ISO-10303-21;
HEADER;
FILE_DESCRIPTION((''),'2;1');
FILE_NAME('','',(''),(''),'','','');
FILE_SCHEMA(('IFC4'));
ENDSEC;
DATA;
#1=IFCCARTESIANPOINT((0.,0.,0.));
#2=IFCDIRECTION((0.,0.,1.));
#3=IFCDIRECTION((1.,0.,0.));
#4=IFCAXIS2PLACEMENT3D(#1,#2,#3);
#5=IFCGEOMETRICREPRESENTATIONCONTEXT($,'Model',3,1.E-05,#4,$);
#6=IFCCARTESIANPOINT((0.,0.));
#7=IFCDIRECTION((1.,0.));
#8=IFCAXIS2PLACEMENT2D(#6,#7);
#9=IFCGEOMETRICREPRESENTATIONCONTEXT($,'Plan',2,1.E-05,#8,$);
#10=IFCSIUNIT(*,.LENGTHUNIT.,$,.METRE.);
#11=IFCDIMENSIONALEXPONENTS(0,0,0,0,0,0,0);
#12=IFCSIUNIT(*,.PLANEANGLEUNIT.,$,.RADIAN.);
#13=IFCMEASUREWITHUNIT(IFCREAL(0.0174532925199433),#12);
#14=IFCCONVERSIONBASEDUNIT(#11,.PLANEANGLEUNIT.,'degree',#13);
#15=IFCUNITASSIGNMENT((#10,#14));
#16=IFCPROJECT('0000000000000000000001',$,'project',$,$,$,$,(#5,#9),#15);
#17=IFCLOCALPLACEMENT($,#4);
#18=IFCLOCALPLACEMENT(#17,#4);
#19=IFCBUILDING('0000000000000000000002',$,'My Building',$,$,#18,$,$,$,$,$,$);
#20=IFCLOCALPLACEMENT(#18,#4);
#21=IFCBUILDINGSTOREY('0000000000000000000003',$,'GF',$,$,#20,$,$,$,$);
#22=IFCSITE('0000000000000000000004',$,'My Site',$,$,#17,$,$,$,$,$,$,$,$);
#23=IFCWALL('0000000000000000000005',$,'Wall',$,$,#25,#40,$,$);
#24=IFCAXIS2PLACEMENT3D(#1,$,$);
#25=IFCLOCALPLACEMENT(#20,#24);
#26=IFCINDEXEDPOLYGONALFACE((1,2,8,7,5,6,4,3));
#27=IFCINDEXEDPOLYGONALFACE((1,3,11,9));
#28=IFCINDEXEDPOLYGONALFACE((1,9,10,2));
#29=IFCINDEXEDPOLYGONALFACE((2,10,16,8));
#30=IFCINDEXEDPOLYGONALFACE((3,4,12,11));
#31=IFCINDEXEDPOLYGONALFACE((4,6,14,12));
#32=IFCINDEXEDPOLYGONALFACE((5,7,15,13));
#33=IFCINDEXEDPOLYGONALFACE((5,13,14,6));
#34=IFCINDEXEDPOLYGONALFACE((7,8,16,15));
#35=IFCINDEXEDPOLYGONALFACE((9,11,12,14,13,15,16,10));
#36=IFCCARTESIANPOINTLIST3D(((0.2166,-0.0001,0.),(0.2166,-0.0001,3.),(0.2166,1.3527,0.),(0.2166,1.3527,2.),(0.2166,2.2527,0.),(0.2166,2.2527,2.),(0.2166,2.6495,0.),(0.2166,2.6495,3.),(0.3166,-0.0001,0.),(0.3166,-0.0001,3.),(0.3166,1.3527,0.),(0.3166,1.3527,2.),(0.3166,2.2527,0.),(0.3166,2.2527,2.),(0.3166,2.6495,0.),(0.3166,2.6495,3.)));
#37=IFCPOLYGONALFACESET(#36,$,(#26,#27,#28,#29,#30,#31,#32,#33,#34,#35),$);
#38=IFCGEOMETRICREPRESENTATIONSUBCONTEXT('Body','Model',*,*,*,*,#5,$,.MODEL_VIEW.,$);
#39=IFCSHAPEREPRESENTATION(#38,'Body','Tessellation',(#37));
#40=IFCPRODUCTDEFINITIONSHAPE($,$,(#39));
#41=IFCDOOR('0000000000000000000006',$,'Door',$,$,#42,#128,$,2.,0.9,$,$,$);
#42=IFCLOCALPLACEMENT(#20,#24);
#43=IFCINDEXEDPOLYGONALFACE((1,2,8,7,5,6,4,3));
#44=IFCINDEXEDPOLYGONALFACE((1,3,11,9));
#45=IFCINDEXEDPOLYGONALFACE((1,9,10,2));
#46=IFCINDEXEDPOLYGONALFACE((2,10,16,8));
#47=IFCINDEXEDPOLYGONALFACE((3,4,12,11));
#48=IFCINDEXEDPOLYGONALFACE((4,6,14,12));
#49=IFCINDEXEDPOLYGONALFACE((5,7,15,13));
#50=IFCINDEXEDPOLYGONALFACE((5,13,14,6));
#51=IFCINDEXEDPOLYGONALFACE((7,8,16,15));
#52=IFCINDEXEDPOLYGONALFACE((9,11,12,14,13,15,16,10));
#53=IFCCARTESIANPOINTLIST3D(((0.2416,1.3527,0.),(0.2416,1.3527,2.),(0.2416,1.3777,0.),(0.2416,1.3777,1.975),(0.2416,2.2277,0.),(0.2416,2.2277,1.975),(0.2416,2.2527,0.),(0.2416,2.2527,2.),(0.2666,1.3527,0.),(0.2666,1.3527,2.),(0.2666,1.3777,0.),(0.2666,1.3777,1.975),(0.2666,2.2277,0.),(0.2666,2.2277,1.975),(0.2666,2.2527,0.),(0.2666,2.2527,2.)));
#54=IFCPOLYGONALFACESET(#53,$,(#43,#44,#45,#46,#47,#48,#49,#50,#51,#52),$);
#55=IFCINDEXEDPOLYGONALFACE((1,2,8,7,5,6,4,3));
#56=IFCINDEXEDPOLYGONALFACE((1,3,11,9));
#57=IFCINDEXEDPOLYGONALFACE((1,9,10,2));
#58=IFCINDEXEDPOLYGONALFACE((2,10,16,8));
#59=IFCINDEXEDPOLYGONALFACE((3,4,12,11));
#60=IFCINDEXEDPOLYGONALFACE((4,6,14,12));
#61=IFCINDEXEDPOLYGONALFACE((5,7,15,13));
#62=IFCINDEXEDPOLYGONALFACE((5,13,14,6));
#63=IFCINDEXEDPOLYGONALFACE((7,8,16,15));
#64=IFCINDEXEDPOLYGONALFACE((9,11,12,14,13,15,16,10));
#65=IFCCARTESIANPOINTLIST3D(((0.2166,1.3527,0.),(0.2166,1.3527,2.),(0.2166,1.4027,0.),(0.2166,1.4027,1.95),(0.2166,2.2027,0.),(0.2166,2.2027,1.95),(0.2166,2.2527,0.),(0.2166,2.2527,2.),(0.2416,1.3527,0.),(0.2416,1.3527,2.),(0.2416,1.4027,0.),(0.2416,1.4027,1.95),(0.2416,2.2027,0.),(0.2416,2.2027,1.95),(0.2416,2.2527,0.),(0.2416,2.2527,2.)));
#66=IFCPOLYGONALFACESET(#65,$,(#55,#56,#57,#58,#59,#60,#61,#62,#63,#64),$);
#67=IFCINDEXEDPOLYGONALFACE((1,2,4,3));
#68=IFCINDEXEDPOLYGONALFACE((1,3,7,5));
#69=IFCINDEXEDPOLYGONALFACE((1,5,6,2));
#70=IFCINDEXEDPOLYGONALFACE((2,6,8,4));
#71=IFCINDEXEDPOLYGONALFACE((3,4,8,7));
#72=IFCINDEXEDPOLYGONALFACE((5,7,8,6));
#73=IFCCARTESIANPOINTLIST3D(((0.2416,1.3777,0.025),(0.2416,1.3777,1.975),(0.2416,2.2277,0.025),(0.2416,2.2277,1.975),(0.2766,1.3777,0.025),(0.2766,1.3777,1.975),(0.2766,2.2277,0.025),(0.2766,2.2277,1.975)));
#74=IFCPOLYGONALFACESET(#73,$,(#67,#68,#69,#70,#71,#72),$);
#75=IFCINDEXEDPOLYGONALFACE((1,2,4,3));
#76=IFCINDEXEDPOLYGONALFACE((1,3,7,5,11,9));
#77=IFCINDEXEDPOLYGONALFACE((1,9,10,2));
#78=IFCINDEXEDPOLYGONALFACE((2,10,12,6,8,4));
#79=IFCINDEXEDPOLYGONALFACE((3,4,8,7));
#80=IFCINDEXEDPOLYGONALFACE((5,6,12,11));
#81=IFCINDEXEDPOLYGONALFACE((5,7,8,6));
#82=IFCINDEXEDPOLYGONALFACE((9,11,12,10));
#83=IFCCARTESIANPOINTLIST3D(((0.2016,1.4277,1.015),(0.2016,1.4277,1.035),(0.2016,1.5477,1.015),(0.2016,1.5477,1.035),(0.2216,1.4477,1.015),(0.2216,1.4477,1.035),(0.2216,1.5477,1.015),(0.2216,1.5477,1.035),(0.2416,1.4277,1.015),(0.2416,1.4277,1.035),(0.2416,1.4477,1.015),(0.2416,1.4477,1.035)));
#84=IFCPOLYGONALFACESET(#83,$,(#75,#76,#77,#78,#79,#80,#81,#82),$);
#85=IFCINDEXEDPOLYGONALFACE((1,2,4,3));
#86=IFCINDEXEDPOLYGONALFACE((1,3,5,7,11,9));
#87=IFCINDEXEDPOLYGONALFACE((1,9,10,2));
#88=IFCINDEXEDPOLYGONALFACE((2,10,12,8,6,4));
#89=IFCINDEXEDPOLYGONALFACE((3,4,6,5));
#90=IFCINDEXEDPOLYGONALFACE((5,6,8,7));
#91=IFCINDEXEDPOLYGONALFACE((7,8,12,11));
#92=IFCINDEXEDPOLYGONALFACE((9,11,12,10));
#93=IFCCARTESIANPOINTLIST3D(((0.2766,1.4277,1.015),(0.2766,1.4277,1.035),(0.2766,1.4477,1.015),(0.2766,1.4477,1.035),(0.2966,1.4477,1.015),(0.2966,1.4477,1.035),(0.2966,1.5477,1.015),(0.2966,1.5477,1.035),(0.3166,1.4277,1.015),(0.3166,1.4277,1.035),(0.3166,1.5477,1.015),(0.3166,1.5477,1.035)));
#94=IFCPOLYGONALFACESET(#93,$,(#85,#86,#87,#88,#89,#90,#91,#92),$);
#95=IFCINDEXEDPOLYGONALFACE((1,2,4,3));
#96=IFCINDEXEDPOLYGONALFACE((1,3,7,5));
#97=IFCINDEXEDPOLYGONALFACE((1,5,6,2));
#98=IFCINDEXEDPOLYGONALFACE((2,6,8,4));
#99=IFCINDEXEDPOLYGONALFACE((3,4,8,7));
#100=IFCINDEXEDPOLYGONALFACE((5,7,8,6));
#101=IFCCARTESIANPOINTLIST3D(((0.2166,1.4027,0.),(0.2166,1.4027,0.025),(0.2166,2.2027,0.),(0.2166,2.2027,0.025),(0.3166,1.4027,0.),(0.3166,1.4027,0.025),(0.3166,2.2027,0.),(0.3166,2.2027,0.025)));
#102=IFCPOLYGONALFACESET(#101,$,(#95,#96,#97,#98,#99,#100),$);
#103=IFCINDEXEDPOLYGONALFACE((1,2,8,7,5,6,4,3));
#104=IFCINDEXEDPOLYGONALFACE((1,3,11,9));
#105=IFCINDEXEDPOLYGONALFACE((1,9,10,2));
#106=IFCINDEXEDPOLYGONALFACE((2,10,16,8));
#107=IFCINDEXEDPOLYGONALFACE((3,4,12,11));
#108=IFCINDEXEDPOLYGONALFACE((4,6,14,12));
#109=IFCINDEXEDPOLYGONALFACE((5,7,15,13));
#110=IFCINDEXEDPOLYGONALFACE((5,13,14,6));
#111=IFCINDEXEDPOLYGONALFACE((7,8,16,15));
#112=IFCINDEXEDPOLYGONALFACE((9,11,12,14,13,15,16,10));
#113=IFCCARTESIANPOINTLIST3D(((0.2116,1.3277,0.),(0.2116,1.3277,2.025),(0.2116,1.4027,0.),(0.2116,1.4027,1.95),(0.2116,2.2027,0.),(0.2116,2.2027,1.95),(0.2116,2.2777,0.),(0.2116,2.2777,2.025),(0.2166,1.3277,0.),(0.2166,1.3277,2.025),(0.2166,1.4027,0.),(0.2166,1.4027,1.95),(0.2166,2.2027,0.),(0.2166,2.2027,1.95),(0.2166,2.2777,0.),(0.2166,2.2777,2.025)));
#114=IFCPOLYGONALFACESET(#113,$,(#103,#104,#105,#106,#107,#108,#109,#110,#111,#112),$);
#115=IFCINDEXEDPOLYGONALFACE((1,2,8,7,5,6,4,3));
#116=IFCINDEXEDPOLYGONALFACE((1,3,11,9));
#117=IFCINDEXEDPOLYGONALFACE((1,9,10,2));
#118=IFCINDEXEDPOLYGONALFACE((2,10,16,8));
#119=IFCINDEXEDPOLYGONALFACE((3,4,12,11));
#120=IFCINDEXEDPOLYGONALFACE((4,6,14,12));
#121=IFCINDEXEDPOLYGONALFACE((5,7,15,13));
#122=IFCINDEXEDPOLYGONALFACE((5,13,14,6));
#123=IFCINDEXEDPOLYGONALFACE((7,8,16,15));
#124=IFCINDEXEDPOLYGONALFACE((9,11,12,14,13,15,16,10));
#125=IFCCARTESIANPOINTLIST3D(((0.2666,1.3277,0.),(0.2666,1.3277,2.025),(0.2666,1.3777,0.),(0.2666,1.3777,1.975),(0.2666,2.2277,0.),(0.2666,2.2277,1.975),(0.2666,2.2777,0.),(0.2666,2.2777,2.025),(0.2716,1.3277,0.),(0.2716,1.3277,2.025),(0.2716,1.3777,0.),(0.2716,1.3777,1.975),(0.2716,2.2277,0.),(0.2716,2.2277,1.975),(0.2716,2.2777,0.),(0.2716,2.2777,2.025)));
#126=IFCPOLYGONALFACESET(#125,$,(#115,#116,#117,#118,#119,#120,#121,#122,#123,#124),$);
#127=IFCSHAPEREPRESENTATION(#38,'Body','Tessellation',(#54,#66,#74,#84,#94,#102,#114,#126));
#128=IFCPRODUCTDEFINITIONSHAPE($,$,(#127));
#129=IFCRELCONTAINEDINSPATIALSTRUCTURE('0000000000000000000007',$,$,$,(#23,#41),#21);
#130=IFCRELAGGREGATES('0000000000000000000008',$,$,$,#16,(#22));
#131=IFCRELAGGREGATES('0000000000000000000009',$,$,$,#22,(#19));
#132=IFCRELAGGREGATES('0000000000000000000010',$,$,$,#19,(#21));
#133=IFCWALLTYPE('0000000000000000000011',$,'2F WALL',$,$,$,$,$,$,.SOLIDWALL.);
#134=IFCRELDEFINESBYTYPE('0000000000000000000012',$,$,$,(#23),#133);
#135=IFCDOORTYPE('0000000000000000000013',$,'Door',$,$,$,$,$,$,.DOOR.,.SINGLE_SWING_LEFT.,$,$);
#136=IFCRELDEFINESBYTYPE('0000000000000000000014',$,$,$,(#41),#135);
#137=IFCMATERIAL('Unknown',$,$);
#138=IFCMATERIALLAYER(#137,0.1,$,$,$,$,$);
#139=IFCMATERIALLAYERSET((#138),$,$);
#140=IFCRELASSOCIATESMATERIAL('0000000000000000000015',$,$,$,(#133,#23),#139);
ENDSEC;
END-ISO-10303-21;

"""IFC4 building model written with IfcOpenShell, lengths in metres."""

from ifc_helpers import new_model, entity, si_unit, converted_unit, frame, origin_with_axes, origin_2d_with_axis, place, context, subcontext, project, spatial, line, indexed_curve, outline, extrude, shape, source, transform, mapped, material, layer, layer_set, layer_usage, type_object, type_shapes, element, fill, save


model = new_model("IFC4")

# Units and contexts
model_context = context("Model", 3, precision=1e-05, world=origin_with_axes())
plan_context = context("Plan", 2, precision=1e-05, world=origin_2d_with_axis())
body_context_1 = subcontext(model_context, "Body", "Model", "MODEL_VIEW")
body_context_2 = subcontext(plan_context, "Body", "Plan", "PLAN_VIEW")
ifc_project = project(units=[si_unit("LENGTHUNIT", "METRE"), converted_unit("PLANEANGLEUNIT", "degree", entity("IfcReal", 0.0174532925199433), si_unit("PLANEANGLEUNIT", "RADIAN"), dimensions=[0, 0, 0, 0, 0, 0, 0])], contexts=[model_context, plan_context])

# Site, building, storey
site_placement = place(None, origin_with_axes())
site = spatial("IfcSite", under=ifc_project, at=site_placement, Name="My Site")
building_placement = place(site_placement, origin_with_axes())
building = spatial("IfcBuilding", under=site, at=building_placement, Name="My Building")
storey_placement = place(building_placement, origin_with_axes())
storey = spatial("IfcBuildingStorey", under=building, at=storey_placement, Name="GF")

# Shared definitions
ifc_material = material(Name="Unknown")

# Shared definitions
shared_shape_1 = source(origin_with_axes(), body_context_1, "Body", "SweptSolid", [
    extrude(outline(indexed_curve([(0.0, 0.0), (0.9, 0.0), (0.9, 2.0), (0.0, 2.0)], segments=[line(1, 2, 3, 4, 1)])), frame((0.0, -0.6, 0.0), z_axis=(0.0, -1.0, 0.0), x_axis=(1.0, 0.0, 0.0)), (0.0, 0.0, -1.0), 1.2),
])
door_type = type_object("IfcDoorType", Name="Door", OperationType="SINGLE_SWING_LEFT", PredefinedType="DOOR")
shared_shape_2 = source(origin_with_axes(), body_context_1, "Body", "SweptSolid", [
    extrude(outline(indexed_curve([(0.0, 0.0), (0.0, 2.0), (0.9, 2.0), (0.9, 0.0), (0.875, 0.0), (0.875, 1.975), (0.025, 1.975), (0.025, 0.0)], segments=[line(1, 2, 3, 4, 5, 6, 7, 8, 1)])), frame((0.0, 0.025, 0.0), z_axis=(0.0, -1.0, 0.0), x_axis=(1.0, 0.0, 0.0)), (0.0, 0.0, -1.0), 0.025),
    extrude(outline(indexed_curve([(0.0, 0.0), (0.0, 2.0), (0.9, 2.0), (0.9, 0.0), (0.85, 0.0), (0.85, 1.95), (0.05, 1.95), (0.05, 0.0)], segments=[line(1, 2, 3, 4, 5, 6, 7, 8, 1)])), frame((0.0, 0.0, 0.0), z_axis=(0.0, -1.0, 0.0), x_axis=(1.0, 0.0, 0.0)), (0.0, 0.0, -1.0), 0.025),
    extrude(outline(indexed_curve([(0.0, 0.0), (0.85, 0.0), (0.85, 0.035), (0.0, 0.035)], segments=[line(1, 2, 3, 4, 1)])), frame((0.025, 0.025, 0.025), z_axis=(0.0, 0.0, 1.0), x_axis=(1.0, 0.0, 0.0)), (0.0, 0.0, 1.0), 1.95),
    extrude(outline(indexed_curve([(0.0, 0.0), (0.0, -0.04), (-0.12, -0.04), (-0.12, -0.02), (-0.02, -0.02), (-0.02, 0.0)], segments=[line(1, 2, 3, 4, 5, 6, 1)])), frame((0.825, 0.025, 1.015), z_axis=(0.0, 0.0, 1.0), x_axis=(1.0, 0.0, 0.0)), (0.0, 0.0, 1.0), 0.02),
    extrude(outline(indexed_curve([(0.0, 0.0), (0.0, 0.04), (-0.12, 0.04), (-0.12, 0.02), (-0.02, 0.02), (-0.02, 0.0)], segments=[line(1, 2, 3, 4, 5, 6, 1)])), frame((0.825, 0.06, 1.015), z_axis=(0.0, 0.0, 1.0), x_axis=(1.0, 0.0, 0.0)), (0.0, 0.0, 1.0), 0.02),
    extrude(outline(indexed_curve([(0.0, 0.0), (0.8, 0.0), (0.8, 0.1), (0.0, 0.1)], segments=[line(1, 2, 3, 4, 1)])), frame((0.05, 0.0, 0.0), z_axis=(0.0, 0.0, 1.0), x_axis=(1.0, 0.0, 0.0)), (0.0, 0.0, 1.0), 0.025),
    extrude(outline(indexed_curve([(0.0, 0.0), (0.0, 2.025), (0.95, 2.025), (0.95, 0.0), (0.875, 0.0), (0.875, 1.95), (0.075, 1.95), (0.075, 0.0)], segments=[line(1, 2, 3, 4, 5, 6, 7, 8, 1)])), frame((-0.025, -0.005, 0.0), z_axis=(0.0, -1.0, 0.0), x_axis=(1.0, 0.0, 0.0)), (0.0, 0.0, -1.0), 0.005),
    extrude(outline(indexed_curve([(0.0, 0.0), (0.0, 2.025), (0.95, 2.025), (0.95, 0.0), (0.9, 0.0), (0.9, 1.975), (0.05, 1.975), (0.05, 0.0)], segments=[line(1, 2, 3, 4, 5, 6, 7, 8, 1)])), frame((-0.025, 0.05, 0.0), z_axis=(0.0, -1.0, 0.0), x_axis=(1.0, 0.0, 0.0)), (0.0, 0.0, -1.0), 0.005),
])
shared_shape_3 = source(origin_with_axes(), body_context_2, "Body", "Curve2D", [
    entity("IfcIndexedPolyCurve", entity("IfcCartesianPointList2D", [[0.0, 0.0], [0.0, 0.05], [0.025, 0.05], [0.025, 0.025], [0.05, 0.025], [0.05, 0.0]]), [entity("IfcLineIndex", [1, 2, 3, 4, 5, 6, 1])]),
    entity("IfcIndexedPolyCurve", entity("IfcCartesianPointList2D", [[0.9, 0.0], [0.9, 0.05], [0.875, 0.05], [0.875, 0.025], [0.85, 0.025], [0.85, 0.0]]), [entity("IfcLineIndex", [1, 2, 3, 4, 5, 6, 1])]),
    entity("IfcTrimmedCurve", entity("IfcEllipse", entity("IfcAxis2Placement2D", entity("IfcCartesianPoint", [0.06, 0.05]), entity("IfcDirection", [1.0, 0.0])), 0.815, 0.85), [entity("IfcCartesianPoint", [0.875, 0.05])], [entity("IfcCartesianPoint", [0.06, 0.9])], True, "CARTESIAN"),
    entity("IfcIndexedPolyCurve", entity("IfcCartesianPointList2D", [[0.025, 0.05], [0.06, 0.05], [0.06, 0.9], [0.025, 0.9]]), [entity("IfcLineIndex", [1, 2, 3, 4, 1])]),
])
type_shapes(door_type, [shared_shape_2, shared_shape_3])

# Wall, opening, door
ifc_layer_1 = layer(ifc_material, 0.1)
ifc_layer_set_1 = layer_set([ifc_layer_1])
ifc_layer_usage_1 = layer_usage(ifc_layer_set_1, "AXIS2", "POSITIVE", 0.0)
wall_type_1 = type_object("IfcWallType", Name="2F WALL", PredefinedType="SOLIDWALL", material=ifc_layer_set_1)
wall_1_placement = place(storey_placement, frame((0.2166, 2.6495, 0.0), z_axis=(0.0, 0.0, 1.0), x_axis=(0.0, -1.0, 0.0)))
wall_1 = element("IfcWall", 1, at=wall_1_placement, inside=storey, type_object=wall_type_1, material=ifc_layer_usage_1, Name="Wall", context=body_context_1, shape_type="SweptSolid", body=[
    extrude(outline(indexed_curve([(0.0, 0.0), (0.0, 0.1), (2.6496, 0.1), (2.6496, 0.0)], segments=[line(1, 2, 3, 4, 1)])), origin_with_axes(), (0.0, 0.0, 1.0), 3.0),
])
opening_1_placement = place(wall_1_placement, frame((0.3968, 0.0, 0.0), z_axis=(0.0, 0.0, 1.0), x_axis=(1.0, 0.0, 0.0)))
opening_1 = element("IfcOpeningElement", 2, at=opening_1_placement, cuts=wall_1, PredefinedType="OPENING", context=body_context_1, shape_type="MappedRepresentation", body=[
    mapped(shared_shape_1, transform((0.0, 0.0, 0.0), x_axis=(1.0, 0.0, 0.0), y_axis=(0.0, 1.0, 0.0), z_axis=(0.0, 0.0, 1.0), scale=1.0)),
])
door_1_placement = place(opening_1_placement, frame((0.0, 0.0, 0.0), z_axis=(0.0, 0.0, 1.0), x_axis=(1.0, 0.0, 0.0)))
door_1 = element("IfcDoor", 3, at=door_1_placement, inside=storey, type_object=door_type, Name="Door", OverallHeight=2.0, OverallWidth=0.9, shapes=[
    shape(body_context_1, "Body", "MappedRepresentation", [mapped(shared_shape_2, transform((0.0, 0.0, 0.0), x_axis=(1.0, 0.0, 0.0), y_axis=(0.0, 1.0, 0.0), z_axis=(0.0, 0.0, 1.0), scale=1.0))]),
    shape(body_context_2, "Body", "MappedRepresentation", [mapped(shared_shape_3, transform((0.0, 0.0, 0.0), x_axis=(1.0, 0.0, 0.0), y_axis=(0.0, 1.0, 0.0), z_axis=(0.0, 0.0, 1.0), scale=1.0))]),
])
fill(opening_1, door_1)

save(model, "model.ifc")
